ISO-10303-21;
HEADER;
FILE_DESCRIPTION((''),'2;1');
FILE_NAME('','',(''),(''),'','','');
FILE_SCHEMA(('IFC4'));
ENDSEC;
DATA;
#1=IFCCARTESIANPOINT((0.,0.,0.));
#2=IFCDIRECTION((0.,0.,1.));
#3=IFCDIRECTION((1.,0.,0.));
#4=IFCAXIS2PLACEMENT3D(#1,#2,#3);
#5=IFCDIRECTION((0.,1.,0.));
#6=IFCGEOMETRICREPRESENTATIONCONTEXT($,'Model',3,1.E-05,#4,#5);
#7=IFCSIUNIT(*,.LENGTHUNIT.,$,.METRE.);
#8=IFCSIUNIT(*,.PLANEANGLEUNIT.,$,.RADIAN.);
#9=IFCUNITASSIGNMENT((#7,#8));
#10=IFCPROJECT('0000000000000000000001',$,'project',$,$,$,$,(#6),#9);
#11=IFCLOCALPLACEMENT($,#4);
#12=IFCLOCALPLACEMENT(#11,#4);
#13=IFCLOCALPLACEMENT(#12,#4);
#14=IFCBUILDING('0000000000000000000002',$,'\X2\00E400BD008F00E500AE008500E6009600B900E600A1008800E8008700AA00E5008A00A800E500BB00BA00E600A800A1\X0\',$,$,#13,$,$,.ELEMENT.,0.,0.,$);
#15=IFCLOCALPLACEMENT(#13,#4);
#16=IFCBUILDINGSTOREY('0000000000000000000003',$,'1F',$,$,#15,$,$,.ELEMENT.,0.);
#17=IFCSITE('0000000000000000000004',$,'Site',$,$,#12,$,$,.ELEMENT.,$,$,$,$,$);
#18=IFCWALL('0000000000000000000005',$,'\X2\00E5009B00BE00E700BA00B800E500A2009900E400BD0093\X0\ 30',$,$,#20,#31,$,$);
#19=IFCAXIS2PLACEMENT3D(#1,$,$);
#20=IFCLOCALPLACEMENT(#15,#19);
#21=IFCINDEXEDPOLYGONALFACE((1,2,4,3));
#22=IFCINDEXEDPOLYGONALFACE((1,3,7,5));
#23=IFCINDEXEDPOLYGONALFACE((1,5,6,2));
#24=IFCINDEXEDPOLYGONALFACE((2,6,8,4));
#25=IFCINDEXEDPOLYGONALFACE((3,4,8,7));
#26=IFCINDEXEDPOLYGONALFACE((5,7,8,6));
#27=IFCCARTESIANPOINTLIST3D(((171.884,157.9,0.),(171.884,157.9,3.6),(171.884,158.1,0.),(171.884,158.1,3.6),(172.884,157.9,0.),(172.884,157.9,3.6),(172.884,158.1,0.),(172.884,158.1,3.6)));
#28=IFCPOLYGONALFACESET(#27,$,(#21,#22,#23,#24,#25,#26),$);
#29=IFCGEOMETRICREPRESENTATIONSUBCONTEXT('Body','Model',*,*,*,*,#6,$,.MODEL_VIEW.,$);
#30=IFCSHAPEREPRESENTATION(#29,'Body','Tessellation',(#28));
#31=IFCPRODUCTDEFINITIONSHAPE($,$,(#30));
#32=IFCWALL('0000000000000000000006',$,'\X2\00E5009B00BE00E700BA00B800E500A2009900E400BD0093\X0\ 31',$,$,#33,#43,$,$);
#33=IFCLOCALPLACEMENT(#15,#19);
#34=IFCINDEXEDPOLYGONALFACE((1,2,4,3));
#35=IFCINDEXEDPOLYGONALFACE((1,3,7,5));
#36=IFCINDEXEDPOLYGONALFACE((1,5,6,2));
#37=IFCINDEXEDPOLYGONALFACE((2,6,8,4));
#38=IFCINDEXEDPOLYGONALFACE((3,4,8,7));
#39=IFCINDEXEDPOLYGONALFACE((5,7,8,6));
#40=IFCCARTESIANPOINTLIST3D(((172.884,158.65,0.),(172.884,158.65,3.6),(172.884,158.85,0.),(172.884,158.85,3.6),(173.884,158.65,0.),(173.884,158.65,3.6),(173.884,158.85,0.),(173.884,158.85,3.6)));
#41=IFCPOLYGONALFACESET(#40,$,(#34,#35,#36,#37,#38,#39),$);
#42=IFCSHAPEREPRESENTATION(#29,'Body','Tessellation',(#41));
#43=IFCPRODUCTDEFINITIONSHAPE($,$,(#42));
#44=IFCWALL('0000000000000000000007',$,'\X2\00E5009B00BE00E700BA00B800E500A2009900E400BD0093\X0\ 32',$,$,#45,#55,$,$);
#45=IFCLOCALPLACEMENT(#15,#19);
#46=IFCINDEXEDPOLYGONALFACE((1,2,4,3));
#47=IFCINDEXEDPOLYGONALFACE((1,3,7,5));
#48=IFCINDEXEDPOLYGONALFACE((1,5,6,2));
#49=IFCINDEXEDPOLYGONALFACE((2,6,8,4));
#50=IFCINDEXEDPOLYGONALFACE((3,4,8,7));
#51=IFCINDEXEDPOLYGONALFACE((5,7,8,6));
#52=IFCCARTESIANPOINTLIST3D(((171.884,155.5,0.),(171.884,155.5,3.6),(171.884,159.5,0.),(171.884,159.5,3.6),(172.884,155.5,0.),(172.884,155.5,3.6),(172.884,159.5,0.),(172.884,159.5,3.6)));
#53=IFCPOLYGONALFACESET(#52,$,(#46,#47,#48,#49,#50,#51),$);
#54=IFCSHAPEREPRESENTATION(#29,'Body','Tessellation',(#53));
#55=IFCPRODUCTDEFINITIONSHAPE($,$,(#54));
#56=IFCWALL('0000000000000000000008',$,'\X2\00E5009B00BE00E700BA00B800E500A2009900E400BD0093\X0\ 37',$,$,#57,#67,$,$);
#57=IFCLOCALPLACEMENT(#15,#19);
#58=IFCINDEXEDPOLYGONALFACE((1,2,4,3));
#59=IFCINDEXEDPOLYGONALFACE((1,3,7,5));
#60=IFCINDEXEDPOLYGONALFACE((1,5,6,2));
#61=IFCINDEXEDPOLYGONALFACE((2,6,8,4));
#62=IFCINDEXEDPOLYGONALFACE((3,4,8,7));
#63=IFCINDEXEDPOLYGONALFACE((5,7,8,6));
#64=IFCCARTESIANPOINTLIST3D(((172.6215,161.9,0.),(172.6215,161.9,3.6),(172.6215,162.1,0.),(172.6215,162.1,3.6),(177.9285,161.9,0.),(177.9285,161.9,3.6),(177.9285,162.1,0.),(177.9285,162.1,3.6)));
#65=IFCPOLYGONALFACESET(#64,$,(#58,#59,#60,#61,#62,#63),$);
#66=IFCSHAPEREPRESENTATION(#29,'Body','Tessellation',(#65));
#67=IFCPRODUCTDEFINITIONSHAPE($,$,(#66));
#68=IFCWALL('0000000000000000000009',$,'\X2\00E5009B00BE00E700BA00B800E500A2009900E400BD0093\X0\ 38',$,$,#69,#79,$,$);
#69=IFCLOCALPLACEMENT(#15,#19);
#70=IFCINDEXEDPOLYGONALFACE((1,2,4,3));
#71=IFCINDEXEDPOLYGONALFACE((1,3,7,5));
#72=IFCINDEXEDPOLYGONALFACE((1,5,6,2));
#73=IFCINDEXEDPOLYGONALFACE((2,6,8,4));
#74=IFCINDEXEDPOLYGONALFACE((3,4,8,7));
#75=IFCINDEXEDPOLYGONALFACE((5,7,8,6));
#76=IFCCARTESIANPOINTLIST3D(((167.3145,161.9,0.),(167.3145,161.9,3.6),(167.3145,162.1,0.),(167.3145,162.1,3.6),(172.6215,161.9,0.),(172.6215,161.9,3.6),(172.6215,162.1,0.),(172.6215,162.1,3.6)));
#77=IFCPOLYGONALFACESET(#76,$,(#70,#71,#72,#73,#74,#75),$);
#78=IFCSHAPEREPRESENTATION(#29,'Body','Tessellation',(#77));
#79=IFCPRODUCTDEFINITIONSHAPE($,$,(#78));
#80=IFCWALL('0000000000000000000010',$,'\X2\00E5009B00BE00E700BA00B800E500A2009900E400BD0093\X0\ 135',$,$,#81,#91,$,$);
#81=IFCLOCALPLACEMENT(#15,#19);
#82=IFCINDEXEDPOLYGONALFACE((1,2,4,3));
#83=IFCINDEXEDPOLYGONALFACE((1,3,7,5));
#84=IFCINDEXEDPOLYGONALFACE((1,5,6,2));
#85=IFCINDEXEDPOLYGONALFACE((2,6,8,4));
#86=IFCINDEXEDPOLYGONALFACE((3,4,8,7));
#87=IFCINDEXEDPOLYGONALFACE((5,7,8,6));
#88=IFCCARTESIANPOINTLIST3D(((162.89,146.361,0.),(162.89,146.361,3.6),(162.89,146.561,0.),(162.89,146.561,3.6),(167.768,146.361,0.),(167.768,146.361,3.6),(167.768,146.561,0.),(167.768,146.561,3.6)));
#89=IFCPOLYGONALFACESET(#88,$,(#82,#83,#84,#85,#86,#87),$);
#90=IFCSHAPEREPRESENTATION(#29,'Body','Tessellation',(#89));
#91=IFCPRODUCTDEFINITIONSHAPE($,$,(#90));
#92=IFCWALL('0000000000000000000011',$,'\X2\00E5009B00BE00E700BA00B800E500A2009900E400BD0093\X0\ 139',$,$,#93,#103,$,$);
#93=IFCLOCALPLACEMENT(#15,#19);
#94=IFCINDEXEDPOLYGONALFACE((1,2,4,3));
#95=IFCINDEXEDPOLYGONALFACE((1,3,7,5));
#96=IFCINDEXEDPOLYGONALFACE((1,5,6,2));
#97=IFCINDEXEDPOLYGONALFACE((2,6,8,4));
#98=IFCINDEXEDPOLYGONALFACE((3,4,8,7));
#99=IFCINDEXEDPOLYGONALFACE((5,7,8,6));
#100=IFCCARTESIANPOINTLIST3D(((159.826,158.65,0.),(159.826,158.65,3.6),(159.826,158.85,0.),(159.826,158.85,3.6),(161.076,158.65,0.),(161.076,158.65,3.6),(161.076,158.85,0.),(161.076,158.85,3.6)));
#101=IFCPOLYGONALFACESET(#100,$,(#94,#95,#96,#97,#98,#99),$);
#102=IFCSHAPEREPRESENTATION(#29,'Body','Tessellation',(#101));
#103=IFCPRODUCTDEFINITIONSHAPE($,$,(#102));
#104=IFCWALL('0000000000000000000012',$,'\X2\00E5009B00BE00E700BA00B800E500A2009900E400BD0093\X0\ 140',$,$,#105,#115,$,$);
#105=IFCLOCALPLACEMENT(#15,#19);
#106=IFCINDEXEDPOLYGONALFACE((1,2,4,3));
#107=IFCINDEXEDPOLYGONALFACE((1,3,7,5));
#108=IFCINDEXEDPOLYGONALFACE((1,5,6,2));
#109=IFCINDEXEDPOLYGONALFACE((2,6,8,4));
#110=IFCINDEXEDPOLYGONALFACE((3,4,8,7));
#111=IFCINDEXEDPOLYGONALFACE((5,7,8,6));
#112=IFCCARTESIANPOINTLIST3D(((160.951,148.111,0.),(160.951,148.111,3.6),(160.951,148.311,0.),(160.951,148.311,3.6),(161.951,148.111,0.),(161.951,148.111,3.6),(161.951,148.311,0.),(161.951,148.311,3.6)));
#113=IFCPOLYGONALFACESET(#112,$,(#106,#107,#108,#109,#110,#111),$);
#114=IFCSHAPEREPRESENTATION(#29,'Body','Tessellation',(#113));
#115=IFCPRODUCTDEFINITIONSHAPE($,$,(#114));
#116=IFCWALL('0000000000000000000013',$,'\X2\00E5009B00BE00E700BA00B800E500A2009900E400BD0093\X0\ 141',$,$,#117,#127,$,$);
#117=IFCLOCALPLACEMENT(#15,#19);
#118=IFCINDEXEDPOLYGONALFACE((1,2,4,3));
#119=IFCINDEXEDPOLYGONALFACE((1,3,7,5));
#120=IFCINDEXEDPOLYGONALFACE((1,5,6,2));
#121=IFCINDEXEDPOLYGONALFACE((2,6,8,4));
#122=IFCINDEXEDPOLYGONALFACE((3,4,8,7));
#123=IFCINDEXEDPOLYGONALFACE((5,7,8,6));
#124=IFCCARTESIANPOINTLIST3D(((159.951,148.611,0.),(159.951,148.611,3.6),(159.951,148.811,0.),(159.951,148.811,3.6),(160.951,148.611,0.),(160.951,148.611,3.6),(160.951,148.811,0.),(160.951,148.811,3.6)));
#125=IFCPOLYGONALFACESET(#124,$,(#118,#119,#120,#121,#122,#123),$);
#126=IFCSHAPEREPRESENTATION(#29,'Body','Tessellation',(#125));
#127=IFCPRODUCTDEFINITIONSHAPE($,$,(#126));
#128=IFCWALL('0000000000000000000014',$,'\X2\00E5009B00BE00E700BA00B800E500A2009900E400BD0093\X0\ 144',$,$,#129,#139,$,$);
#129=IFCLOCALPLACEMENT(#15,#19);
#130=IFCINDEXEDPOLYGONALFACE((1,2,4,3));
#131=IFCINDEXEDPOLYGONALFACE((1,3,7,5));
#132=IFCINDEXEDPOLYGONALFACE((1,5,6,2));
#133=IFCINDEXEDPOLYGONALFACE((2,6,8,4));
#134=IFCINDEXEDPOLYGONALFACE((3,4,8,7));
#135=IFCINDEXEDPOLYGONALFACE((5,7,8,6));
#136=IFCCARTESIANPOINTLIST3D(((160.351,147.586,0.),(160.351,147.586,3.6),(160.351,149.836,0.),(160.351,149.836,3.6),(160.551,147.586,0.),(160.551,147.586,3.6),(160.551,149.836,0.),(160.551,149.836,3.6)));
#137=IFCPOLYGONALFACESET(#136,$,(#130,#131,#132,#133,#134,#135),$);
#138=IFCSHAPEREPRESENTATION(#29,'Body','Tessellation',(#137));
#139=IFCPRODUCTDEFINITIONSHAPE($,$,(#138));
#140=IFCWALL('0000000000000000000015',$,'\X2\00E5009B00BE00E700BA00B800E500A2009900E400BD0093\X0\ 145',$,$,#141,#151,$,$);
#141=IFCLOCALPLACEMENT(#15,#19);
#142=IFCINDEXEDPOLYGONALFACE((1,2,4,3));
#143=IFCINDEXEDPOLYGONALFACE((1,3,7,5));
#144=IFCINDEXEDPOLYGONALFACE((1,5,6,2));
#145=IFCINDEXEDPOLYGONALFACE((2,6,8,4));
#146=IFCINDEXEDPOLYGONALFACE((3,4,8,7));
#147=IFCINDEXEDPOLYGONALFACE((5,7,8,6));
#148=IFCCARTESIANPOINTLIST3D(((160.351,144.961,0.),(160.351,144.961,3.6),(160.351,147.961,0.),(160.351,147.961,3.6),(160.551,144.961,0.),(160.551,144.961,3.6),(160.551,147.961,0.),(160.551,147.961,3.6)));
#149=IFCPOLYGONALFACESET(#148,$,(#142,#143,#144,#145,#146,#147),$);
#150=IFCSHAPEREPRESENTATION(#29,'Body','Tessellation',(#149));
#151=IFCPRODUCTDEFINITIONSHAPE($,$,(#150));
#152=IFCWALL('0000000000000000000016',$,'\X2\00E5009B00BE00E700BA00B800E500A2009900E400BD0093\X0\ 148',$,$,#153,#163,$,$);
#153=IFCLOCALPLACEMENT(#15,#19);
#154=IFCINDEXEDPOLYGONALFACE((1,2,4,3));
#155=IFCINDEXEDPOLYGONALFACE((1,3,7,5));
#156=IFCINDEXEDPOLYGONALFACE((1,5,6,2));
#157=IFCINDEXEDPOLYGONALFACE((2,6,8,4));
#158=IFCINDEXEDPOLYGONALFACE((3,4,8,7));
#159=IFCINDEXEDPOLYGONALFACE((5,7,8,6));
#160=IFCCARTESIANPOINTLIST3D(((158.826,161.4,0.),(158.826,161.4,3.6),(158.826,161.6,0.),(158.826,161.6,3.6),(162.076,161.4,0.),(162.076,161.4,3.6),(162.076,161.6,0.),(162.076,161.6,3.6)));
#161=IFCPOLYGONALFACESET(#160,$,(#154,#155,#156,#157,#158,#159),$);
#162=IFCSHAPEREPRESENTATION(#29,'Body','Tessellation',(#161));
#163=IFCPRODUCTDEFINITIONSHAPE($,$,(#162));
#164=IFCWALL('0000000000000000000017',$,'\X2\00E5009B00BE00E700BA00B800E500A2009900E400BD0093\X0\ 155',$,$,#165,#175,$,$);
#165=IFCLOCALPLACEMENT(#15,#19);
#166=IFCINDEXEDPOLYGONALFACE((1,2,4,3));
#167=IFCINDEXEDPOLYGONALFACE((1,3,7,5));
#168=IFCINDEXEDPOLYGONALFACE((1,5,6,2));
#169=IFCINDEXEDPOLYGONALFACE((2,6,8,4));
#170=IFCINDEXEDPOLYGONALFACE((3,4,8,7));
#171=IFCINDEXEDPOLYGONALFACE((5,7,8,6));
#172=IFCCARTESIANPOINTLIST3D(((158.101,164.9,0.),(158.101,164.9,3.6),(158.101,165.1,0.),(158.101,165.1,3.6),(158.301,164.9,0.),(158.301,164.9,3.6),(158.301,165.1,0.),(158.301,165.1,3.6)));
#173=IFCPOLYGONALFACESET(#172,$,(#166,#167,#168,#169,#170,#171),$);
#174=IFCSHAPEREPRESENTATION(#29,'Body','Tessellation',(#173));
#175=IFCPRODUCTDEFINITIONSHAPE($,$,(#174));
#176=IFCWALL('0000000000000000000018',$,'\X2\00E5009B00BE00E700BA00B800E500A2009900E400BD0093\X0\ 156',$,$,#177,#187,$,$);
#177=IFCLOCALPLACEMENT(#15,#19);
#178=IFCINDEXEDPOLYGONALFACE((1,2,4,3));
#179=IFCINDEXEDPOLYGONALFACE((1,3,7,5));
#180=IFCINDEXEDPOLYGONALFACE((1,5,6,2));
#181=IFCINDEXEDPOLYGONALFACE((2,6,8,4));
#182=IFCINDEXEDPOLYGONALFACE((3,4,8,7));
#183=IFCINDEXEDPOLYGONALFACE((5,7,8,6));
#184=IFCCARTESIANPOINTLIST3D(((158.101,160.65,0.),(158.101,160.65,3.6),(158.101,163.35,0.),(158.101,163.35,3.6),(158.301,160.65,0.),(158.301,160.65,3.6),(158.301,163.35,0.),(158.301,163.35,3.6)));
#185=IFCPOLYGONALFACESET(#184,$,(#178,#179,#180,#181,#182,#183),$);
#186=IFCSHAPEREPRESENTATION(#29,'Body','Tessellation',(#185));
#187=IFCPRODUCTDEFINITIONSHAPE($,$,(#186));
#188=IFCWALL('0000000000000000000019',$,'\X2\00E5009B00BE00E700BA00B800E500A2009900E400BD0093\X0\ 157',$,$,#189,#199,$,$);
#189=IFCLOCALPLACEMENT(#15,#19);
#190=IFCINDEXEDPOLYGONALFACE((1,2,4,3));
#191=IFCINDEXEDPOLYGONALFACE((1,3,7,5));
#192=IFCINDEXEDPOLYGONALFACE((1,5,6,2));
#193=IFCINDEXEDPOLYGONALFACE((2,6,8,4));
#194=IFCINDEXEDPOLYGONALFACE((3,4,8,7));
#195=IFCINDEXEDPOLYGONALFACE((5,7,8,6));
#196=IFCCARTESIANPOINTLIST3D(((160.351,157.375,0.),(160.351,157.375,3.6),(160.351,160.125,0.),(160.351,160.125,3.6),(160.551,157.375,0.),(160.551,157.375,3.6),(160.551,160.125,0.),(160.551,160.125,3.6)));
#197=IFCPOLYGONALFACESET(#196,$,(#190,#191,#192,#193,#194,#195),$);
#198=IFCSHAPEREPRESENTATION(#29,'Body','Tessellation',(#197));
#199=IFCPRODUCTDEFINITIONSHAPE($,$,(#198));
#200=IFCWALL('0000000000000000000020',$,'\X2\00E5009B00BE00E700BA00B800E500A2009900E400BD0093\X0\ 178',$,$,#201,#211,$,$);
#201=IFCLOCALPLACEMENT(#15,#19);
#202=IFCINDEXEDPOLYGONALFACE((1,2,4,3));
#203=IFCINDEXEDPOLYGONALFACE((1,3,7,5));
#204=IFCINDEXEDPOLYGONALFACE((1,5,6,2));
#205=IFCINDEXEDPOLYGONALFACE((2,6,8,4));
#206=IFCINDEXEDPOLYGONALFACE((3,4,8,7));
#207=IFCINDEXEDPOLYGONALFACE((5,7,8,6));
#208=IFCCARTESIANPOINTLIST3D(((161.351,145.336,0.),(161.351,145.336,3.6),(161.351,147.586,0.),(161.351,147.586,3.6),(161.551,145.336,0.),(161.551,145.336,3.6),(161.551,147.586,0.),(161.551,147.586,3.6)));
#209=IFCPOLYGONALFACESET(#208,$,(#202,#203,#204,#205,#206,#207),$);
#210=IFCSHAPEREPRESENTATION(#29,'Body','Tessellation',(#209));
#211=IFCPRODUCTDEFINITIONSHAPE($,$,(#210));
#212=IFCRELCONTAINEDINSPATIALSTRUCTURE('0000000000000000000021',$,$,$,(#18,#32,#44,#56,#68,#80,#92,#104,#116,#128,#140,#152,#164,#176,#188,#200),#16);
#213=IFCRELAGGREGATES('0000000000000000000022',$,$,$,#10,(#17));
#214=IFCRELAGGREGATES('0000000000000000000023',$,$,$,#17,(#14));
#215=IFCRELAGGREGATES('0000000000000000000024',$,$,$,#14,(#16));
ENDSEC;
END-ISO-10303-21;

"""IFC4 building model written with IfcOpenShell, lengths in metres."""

from ifc_helpers import new_model, si_unit, direction, frame, frame_2d, origin_with_axes, place, context, subcontext, project, spatial, rectangle, extrude, element, save


model = new_model("IFC4")

# Units and contexts
model_context = context("Model", 3, precision=1e-05, world=origin_with_axes(), true_north=direction((0.0, 1.0, 0.0)))
body_context = subcontext(model_context, "Body", "Model", "MODEL_VIEW")
ifc_project = project(units=[si_unit("LENGTHUNIT", "METRE"), si_unit("PLANEANGLEUNIT", "RADIAN")], contexts=[model_context])

# Site, building, storey
placement = place(None, origin_with_axes())
site_placement = place(placement, origin_with_axes())
site = spatial("IfcSite", under=ifc_project, at=site_placement, Name="Site", CompositionType="ELEMENT")
building_placement = place(site_placement, origin_with_axes())
building = spatial("IfcBuilding", under=site, at=building_placement, Name="ä½\u008få®\u0085æ\u0096¹æ¡\u0088è\u0087ªå\u008a¨å»ºæ¨¡", CompositionType="ELEMENT", ElevationOfRefHeight=0.0, ElevationOfTerrain=0.0)
storey_placement = place(building_placement, origin_with_axes())
storey = spatial("IfcBuildingStorey", under=building, at=storey_placement, Name="1F", CompositionType="ELEMENT", Elevation=0.0)

# Walls
for number, where, z_axis, x_axis, name in (
    (1, (172.384, 158.0, 0.0), (0.0, 0.0, 1.0), (1.0, 0.0, 0.0), "å\u009b¾çº¸å¢\u0099ä½\u0093 30"),
    (2, (173.384, 158.75, 0.0), (0.0, 0.0, 1.0), (-1.0, 0.0, 0.0), "å\u009b¾çº¸å¢\u0099ä½\u0093 31"),
):
    element("IfcWall", number, at=place(storey_placement, frame(where, z_axis=z_axis, x_axis=x_axis)), inside=storey, Name=name, context=body_context, shape_type="SweptSolid", body=[
        extrude(rectangle(XDim=1.0, YDim=0.2, at=frame_2d((0.0, 0.0), x_axis=(1.0, 0.0, 0.0))), frame((0.0, 0.0, 0.0), z_axis=(0.0, 0.0, 1.0)), (0.0, 0.0, 1.0), 3.6),
    ])
wall_1_placement = place(storey_placement, frame((172.384, 157.5, 0.0), z_axis=(0.0, 0.0, 1.0), x_axis=(1.0, 0.0, 0.0)))
element("IfcWall", 3, at=wall_1_placement, inside=storey, Name="å\u009b¾çº¸å¢\u0099ä½\u0093 32", context=body_context, shape_type="SweptSolid", body=[
    extrude(rectangle(XDim=1.0, YDim=4.0, at=frame_2d((0.0, 0.0), x_axis=(1.0, 0.0, 0.0))), frame((0.0, 0.0, 0.0), z_axis=(0.0, 0.0, 1.0)), (0.0, 0.0, 1.0), 3.6),
])
for number, where, z_axis, x_axis, name in (
    (4, (175.275, 162.0, 0.0), (0.0, 0.0, 1.0), (-1.0, 0.0, 0.0), "å\u009b¾çº¸å¢\u0099ä½\u0093 37"),
    (5, (169.968, 162.0, 0.0), (0.0, 0.0, 1.0), (1.0, 0.0, 0.0), "å\u009b¾çº¸å¢\u0099ä½\u0093 38"),
):
    element("IfcWall", number, at=place(storey_placement, frame(where, z_axis=z_axis, x_axis=x_axis)), inside=storey, Name=name, context=body_context, shape_type="SweptSolid", body=[
        extrude(rectangle(XDim=5.307, YDim=0.2, at=frame_2d((0.0, 0.0), x_axis=(1.0, 0.0, 0.0))), frame((0.0, 0.0, 0.0), z_axis=(0.0, 0.0, 1.0)), (0.0, 0.0, 1.0), 3.6),
    ])
wall_2_placement = place(storey_placement, frame((165.329, 146.461, 0.0), z_axis=(0.0, 0.0, 1.0), x_axis=(-1.0, 0.0, 0.0)))
element("IfcWall", 6, at=wall_2_placement, inside=storey, Name="å\u009b¾çº¸å¢\u0099ä½\u0093 135", context=body_context, shape_type="SweptSolid", body=[
    extrude(rectangle(XDim=4.878, YDim=0.2, at=frame_2d((0.0, 0.0), x_axis=(1.0, 0.0, 0.0))), frame((0.0, 0.0, 0.0), z_axis=(0.0, 0.0, 1.0)), (0.0, 0.0, 1.0), 3.6),
])
wall_3_placement = place(storey_placement, frame((160.451, 158.75, 0.0), z_axis=(0.0, 0.0, 1.0), x_axis=(1.0, 0.0, 0.0)))
element("IfcWall", 7, at=wall_3_placement, inside=storey, Name="å\u009b¾çº¸å¢\u0099ä½\u0093 139", context=body_context, shape_type="SweptSolid", body=[
    extrude(rectangle(XDim=1.25, YDim=0.2, at=frame_2d((0.0, 0.0), x_axis=(1.0, 0.0, 0.0))), frame((0.0, 0.0, 0.0), z_axis=(0.0, 0.0, 1.0)), (0.0, 0.0, 1.0), 3.6),
])
for number, where, z_axis, x_axis, name in (
    (8, (161.451, 148.211, 0.0), (0.0, 0.0, 1.0), (-1.0, 0.0, 0.0), "å\u009b¾çº¸å¢\u0099ä½\u0093 140"),
    (9, (160.451, 148.711, 0.0), (0.0, 0.0, 1.0), (1.0, 0.0, 0.0), "å\u009b¾çº¸å¢\u0099ä½\u0093 141"),
):
    element("IfcWall", number, at=place(storey_placement, frame(where, z_axis=z_axis, x_axis=x_axis)), inside=storey, Name=name, context=body_context, shape_type="SweptSolid", body=[
        extrude(rectangle(XDim=1.0, YDim=0.2, at=frame_2d((0.0, 0.0), x_axis=(1.0, 0.0, 0.0))), frame((0.0, 0.0, 0.0), z_axis=(0.0, 0.0, 1.0)), (0.0, 0.0, 1.0), 3.6),
    ])
wall_4_placement = place(storey_placement, frame((160.451, 148.711, 0.0), z_axis=(0.0, 0.0, 1.0), x_axis=(0.0, -1.0, 0.0)))
element("IfcWall", 10, at=wall_4_placement, inside=storey, Name="å\u009b¾çº¸å¢\u0099ä½\u0093 144", context=body_context, shape_type="SweptSolid", body=[
    extrude(rectangle(XDim=2.25, YDim=0.2, at=frame_2d((0.0, 0.0), x_axis=(1.0, 0.0, 0.0))), frame((0.0, 0.0, 0.0), z_axis=(0.0, 0.0, 1.0)), (0.0, 0.0, 1.0), 3.6),
])
wall_5_placement = place(storey_placement, frame((160.451, 146.461, 0.0), z_axis=(0.0, 0.0, 1.0), x_axis=(0.0, -1.0, 0.0)))
element("IfcWall", 11, at=wall_5_placement, inside=storey, Name="å\u009b¾çº¸å¢\u0099ä½\u0093 145", context=body_context, shape_type="SweptSolid", body=[
    extrude(rectangle(XDim=3.0, YDim=0.2, at=frame_2d((0.0, 0.0), x_axis=(1.0, 0.0, 0.0))), frame((0.0, 0.0, 0.0), z_axis=(0.0, 0.0, 1.0)), (0.0, 0.0, 1.0), 3.6),
])
wall_6_placement = place(storey_placement, frame((160.451, 161.5, 0.0), z_axis=(0.0, 0.0, 1.0), x_axis=(-1.0, 0.0, 0.0)))
element("IfcWall", 12, at=wall_6_placement, inside=storey, Name="å\u009b¾çº¸å¢\u0099ä½\u0093 148", context=body_context, shape_type="SweptSolid", body=[
    extrude(rectangle(XDim=3.25, YDim=0.2, at=frame_2d((0.0, 0.0), x_axis=(1.0, 0.0, 0.0))), frame((0.0, 0.0, 0.0), z_axis=(0.0, 0.0, 1.0)), (0.0, 0.0, 1.0), 3.6),
])
wall_7_placement = place(storey_placement, frame((158.201, 165.0, 0.0), z_axis=(0.0, 0.0, 1.0), x_axis=(1.0, 0.0, 0.0)))
element("IfcWall", 13, at=wall_7_placement, inside=storey, Name="å\u009b¾çº¸å¢\u0099ä½\u0093 155", context=body_context, shape_type="SweptSolid", body=[
    extrude(rectangle(XDim=0.2, YDim=0.2, at=frame_2d((0.0, 0.0), x_axis=(1.0, 0.0, 0.0))), frame((0.0, 0.0, 0.0), z_axis=(0.0, 0.0, 1.0)), (0.0, 0.0, 1.0), 3.6),
])
wall_8_placement = place(storey_placement, frame((158.201, 162.0, 0.0), z_axis=(0.0, 0.0, 1.0), x_axis=(0.0, 1.0, 0.0)))
element("IfcWall", 14, at=wall_8_placement, inside=storey, Name="å\u009b¾çº¸å¢\u0099ä½\u0093 156", context=body_context, shape_type="SweptSolid", body=[
    extrude(rectangle(XDim=2.7, YDim=0.2, at=frame_2d((0.0, 0.0), x_axis=(1.0, 0.0, 0.0))), frame((0.0, 0.0, 0.0), z_axis=(0.0, 0.0, 1.0)), (0.0, 0.0, 1.0), 3.6),
])
wall_9_placement = place(storey_placement, frame((160.451, 158.75, 0.0), z_axis=(0.0, 0.0, 1.0), x_axis=(0.0, 1.0, 0.0)))
element("IfcWall", 15, at=wall_9_placement, inside=storey, Name="å\u009b¾çº¸å¢\u0099ä½\u0093 157", context=body_context, shape_type="SweptSolid", body=[
    extrude(rectangle(XDim=2.75, YDim=0.2, at=frame_2d((0.0, 0.0), x_axis=(1.0, 0.0, 0.0))), frame((0.0, 0.0, 0.0), z_axis=(0.0, 0.0, 1.0)), (0.0, 0.0, 1.0), 3.6),
])
wall_10_placement = place(storey_placement, frame((161.451, 146.461, 0.0), z_axis=(0.0, 0.0, 1.0), x_axis=(0.0, 1.0, 0.0)))
element("IfcWall", 16, at=wall_10_placement, inside=storey, Name="å\u009b¾çº¸å¢\u0099ä½\u0093 178", context=body_context, shape_type="SweptSolid", body=[
    extrude(rectangle(XDim=2.25, YDim=0.2, at=frame_2d((0.0, 0.0), x_axis=(1.0, 0.0, 0.0))), frame((0.0, 0.0, 0.0), z_axis=(0.0, 0.0, 1.0)), (0.0, 0.0, 1.0), 3.6),
])

save(model, "model.ifc")
